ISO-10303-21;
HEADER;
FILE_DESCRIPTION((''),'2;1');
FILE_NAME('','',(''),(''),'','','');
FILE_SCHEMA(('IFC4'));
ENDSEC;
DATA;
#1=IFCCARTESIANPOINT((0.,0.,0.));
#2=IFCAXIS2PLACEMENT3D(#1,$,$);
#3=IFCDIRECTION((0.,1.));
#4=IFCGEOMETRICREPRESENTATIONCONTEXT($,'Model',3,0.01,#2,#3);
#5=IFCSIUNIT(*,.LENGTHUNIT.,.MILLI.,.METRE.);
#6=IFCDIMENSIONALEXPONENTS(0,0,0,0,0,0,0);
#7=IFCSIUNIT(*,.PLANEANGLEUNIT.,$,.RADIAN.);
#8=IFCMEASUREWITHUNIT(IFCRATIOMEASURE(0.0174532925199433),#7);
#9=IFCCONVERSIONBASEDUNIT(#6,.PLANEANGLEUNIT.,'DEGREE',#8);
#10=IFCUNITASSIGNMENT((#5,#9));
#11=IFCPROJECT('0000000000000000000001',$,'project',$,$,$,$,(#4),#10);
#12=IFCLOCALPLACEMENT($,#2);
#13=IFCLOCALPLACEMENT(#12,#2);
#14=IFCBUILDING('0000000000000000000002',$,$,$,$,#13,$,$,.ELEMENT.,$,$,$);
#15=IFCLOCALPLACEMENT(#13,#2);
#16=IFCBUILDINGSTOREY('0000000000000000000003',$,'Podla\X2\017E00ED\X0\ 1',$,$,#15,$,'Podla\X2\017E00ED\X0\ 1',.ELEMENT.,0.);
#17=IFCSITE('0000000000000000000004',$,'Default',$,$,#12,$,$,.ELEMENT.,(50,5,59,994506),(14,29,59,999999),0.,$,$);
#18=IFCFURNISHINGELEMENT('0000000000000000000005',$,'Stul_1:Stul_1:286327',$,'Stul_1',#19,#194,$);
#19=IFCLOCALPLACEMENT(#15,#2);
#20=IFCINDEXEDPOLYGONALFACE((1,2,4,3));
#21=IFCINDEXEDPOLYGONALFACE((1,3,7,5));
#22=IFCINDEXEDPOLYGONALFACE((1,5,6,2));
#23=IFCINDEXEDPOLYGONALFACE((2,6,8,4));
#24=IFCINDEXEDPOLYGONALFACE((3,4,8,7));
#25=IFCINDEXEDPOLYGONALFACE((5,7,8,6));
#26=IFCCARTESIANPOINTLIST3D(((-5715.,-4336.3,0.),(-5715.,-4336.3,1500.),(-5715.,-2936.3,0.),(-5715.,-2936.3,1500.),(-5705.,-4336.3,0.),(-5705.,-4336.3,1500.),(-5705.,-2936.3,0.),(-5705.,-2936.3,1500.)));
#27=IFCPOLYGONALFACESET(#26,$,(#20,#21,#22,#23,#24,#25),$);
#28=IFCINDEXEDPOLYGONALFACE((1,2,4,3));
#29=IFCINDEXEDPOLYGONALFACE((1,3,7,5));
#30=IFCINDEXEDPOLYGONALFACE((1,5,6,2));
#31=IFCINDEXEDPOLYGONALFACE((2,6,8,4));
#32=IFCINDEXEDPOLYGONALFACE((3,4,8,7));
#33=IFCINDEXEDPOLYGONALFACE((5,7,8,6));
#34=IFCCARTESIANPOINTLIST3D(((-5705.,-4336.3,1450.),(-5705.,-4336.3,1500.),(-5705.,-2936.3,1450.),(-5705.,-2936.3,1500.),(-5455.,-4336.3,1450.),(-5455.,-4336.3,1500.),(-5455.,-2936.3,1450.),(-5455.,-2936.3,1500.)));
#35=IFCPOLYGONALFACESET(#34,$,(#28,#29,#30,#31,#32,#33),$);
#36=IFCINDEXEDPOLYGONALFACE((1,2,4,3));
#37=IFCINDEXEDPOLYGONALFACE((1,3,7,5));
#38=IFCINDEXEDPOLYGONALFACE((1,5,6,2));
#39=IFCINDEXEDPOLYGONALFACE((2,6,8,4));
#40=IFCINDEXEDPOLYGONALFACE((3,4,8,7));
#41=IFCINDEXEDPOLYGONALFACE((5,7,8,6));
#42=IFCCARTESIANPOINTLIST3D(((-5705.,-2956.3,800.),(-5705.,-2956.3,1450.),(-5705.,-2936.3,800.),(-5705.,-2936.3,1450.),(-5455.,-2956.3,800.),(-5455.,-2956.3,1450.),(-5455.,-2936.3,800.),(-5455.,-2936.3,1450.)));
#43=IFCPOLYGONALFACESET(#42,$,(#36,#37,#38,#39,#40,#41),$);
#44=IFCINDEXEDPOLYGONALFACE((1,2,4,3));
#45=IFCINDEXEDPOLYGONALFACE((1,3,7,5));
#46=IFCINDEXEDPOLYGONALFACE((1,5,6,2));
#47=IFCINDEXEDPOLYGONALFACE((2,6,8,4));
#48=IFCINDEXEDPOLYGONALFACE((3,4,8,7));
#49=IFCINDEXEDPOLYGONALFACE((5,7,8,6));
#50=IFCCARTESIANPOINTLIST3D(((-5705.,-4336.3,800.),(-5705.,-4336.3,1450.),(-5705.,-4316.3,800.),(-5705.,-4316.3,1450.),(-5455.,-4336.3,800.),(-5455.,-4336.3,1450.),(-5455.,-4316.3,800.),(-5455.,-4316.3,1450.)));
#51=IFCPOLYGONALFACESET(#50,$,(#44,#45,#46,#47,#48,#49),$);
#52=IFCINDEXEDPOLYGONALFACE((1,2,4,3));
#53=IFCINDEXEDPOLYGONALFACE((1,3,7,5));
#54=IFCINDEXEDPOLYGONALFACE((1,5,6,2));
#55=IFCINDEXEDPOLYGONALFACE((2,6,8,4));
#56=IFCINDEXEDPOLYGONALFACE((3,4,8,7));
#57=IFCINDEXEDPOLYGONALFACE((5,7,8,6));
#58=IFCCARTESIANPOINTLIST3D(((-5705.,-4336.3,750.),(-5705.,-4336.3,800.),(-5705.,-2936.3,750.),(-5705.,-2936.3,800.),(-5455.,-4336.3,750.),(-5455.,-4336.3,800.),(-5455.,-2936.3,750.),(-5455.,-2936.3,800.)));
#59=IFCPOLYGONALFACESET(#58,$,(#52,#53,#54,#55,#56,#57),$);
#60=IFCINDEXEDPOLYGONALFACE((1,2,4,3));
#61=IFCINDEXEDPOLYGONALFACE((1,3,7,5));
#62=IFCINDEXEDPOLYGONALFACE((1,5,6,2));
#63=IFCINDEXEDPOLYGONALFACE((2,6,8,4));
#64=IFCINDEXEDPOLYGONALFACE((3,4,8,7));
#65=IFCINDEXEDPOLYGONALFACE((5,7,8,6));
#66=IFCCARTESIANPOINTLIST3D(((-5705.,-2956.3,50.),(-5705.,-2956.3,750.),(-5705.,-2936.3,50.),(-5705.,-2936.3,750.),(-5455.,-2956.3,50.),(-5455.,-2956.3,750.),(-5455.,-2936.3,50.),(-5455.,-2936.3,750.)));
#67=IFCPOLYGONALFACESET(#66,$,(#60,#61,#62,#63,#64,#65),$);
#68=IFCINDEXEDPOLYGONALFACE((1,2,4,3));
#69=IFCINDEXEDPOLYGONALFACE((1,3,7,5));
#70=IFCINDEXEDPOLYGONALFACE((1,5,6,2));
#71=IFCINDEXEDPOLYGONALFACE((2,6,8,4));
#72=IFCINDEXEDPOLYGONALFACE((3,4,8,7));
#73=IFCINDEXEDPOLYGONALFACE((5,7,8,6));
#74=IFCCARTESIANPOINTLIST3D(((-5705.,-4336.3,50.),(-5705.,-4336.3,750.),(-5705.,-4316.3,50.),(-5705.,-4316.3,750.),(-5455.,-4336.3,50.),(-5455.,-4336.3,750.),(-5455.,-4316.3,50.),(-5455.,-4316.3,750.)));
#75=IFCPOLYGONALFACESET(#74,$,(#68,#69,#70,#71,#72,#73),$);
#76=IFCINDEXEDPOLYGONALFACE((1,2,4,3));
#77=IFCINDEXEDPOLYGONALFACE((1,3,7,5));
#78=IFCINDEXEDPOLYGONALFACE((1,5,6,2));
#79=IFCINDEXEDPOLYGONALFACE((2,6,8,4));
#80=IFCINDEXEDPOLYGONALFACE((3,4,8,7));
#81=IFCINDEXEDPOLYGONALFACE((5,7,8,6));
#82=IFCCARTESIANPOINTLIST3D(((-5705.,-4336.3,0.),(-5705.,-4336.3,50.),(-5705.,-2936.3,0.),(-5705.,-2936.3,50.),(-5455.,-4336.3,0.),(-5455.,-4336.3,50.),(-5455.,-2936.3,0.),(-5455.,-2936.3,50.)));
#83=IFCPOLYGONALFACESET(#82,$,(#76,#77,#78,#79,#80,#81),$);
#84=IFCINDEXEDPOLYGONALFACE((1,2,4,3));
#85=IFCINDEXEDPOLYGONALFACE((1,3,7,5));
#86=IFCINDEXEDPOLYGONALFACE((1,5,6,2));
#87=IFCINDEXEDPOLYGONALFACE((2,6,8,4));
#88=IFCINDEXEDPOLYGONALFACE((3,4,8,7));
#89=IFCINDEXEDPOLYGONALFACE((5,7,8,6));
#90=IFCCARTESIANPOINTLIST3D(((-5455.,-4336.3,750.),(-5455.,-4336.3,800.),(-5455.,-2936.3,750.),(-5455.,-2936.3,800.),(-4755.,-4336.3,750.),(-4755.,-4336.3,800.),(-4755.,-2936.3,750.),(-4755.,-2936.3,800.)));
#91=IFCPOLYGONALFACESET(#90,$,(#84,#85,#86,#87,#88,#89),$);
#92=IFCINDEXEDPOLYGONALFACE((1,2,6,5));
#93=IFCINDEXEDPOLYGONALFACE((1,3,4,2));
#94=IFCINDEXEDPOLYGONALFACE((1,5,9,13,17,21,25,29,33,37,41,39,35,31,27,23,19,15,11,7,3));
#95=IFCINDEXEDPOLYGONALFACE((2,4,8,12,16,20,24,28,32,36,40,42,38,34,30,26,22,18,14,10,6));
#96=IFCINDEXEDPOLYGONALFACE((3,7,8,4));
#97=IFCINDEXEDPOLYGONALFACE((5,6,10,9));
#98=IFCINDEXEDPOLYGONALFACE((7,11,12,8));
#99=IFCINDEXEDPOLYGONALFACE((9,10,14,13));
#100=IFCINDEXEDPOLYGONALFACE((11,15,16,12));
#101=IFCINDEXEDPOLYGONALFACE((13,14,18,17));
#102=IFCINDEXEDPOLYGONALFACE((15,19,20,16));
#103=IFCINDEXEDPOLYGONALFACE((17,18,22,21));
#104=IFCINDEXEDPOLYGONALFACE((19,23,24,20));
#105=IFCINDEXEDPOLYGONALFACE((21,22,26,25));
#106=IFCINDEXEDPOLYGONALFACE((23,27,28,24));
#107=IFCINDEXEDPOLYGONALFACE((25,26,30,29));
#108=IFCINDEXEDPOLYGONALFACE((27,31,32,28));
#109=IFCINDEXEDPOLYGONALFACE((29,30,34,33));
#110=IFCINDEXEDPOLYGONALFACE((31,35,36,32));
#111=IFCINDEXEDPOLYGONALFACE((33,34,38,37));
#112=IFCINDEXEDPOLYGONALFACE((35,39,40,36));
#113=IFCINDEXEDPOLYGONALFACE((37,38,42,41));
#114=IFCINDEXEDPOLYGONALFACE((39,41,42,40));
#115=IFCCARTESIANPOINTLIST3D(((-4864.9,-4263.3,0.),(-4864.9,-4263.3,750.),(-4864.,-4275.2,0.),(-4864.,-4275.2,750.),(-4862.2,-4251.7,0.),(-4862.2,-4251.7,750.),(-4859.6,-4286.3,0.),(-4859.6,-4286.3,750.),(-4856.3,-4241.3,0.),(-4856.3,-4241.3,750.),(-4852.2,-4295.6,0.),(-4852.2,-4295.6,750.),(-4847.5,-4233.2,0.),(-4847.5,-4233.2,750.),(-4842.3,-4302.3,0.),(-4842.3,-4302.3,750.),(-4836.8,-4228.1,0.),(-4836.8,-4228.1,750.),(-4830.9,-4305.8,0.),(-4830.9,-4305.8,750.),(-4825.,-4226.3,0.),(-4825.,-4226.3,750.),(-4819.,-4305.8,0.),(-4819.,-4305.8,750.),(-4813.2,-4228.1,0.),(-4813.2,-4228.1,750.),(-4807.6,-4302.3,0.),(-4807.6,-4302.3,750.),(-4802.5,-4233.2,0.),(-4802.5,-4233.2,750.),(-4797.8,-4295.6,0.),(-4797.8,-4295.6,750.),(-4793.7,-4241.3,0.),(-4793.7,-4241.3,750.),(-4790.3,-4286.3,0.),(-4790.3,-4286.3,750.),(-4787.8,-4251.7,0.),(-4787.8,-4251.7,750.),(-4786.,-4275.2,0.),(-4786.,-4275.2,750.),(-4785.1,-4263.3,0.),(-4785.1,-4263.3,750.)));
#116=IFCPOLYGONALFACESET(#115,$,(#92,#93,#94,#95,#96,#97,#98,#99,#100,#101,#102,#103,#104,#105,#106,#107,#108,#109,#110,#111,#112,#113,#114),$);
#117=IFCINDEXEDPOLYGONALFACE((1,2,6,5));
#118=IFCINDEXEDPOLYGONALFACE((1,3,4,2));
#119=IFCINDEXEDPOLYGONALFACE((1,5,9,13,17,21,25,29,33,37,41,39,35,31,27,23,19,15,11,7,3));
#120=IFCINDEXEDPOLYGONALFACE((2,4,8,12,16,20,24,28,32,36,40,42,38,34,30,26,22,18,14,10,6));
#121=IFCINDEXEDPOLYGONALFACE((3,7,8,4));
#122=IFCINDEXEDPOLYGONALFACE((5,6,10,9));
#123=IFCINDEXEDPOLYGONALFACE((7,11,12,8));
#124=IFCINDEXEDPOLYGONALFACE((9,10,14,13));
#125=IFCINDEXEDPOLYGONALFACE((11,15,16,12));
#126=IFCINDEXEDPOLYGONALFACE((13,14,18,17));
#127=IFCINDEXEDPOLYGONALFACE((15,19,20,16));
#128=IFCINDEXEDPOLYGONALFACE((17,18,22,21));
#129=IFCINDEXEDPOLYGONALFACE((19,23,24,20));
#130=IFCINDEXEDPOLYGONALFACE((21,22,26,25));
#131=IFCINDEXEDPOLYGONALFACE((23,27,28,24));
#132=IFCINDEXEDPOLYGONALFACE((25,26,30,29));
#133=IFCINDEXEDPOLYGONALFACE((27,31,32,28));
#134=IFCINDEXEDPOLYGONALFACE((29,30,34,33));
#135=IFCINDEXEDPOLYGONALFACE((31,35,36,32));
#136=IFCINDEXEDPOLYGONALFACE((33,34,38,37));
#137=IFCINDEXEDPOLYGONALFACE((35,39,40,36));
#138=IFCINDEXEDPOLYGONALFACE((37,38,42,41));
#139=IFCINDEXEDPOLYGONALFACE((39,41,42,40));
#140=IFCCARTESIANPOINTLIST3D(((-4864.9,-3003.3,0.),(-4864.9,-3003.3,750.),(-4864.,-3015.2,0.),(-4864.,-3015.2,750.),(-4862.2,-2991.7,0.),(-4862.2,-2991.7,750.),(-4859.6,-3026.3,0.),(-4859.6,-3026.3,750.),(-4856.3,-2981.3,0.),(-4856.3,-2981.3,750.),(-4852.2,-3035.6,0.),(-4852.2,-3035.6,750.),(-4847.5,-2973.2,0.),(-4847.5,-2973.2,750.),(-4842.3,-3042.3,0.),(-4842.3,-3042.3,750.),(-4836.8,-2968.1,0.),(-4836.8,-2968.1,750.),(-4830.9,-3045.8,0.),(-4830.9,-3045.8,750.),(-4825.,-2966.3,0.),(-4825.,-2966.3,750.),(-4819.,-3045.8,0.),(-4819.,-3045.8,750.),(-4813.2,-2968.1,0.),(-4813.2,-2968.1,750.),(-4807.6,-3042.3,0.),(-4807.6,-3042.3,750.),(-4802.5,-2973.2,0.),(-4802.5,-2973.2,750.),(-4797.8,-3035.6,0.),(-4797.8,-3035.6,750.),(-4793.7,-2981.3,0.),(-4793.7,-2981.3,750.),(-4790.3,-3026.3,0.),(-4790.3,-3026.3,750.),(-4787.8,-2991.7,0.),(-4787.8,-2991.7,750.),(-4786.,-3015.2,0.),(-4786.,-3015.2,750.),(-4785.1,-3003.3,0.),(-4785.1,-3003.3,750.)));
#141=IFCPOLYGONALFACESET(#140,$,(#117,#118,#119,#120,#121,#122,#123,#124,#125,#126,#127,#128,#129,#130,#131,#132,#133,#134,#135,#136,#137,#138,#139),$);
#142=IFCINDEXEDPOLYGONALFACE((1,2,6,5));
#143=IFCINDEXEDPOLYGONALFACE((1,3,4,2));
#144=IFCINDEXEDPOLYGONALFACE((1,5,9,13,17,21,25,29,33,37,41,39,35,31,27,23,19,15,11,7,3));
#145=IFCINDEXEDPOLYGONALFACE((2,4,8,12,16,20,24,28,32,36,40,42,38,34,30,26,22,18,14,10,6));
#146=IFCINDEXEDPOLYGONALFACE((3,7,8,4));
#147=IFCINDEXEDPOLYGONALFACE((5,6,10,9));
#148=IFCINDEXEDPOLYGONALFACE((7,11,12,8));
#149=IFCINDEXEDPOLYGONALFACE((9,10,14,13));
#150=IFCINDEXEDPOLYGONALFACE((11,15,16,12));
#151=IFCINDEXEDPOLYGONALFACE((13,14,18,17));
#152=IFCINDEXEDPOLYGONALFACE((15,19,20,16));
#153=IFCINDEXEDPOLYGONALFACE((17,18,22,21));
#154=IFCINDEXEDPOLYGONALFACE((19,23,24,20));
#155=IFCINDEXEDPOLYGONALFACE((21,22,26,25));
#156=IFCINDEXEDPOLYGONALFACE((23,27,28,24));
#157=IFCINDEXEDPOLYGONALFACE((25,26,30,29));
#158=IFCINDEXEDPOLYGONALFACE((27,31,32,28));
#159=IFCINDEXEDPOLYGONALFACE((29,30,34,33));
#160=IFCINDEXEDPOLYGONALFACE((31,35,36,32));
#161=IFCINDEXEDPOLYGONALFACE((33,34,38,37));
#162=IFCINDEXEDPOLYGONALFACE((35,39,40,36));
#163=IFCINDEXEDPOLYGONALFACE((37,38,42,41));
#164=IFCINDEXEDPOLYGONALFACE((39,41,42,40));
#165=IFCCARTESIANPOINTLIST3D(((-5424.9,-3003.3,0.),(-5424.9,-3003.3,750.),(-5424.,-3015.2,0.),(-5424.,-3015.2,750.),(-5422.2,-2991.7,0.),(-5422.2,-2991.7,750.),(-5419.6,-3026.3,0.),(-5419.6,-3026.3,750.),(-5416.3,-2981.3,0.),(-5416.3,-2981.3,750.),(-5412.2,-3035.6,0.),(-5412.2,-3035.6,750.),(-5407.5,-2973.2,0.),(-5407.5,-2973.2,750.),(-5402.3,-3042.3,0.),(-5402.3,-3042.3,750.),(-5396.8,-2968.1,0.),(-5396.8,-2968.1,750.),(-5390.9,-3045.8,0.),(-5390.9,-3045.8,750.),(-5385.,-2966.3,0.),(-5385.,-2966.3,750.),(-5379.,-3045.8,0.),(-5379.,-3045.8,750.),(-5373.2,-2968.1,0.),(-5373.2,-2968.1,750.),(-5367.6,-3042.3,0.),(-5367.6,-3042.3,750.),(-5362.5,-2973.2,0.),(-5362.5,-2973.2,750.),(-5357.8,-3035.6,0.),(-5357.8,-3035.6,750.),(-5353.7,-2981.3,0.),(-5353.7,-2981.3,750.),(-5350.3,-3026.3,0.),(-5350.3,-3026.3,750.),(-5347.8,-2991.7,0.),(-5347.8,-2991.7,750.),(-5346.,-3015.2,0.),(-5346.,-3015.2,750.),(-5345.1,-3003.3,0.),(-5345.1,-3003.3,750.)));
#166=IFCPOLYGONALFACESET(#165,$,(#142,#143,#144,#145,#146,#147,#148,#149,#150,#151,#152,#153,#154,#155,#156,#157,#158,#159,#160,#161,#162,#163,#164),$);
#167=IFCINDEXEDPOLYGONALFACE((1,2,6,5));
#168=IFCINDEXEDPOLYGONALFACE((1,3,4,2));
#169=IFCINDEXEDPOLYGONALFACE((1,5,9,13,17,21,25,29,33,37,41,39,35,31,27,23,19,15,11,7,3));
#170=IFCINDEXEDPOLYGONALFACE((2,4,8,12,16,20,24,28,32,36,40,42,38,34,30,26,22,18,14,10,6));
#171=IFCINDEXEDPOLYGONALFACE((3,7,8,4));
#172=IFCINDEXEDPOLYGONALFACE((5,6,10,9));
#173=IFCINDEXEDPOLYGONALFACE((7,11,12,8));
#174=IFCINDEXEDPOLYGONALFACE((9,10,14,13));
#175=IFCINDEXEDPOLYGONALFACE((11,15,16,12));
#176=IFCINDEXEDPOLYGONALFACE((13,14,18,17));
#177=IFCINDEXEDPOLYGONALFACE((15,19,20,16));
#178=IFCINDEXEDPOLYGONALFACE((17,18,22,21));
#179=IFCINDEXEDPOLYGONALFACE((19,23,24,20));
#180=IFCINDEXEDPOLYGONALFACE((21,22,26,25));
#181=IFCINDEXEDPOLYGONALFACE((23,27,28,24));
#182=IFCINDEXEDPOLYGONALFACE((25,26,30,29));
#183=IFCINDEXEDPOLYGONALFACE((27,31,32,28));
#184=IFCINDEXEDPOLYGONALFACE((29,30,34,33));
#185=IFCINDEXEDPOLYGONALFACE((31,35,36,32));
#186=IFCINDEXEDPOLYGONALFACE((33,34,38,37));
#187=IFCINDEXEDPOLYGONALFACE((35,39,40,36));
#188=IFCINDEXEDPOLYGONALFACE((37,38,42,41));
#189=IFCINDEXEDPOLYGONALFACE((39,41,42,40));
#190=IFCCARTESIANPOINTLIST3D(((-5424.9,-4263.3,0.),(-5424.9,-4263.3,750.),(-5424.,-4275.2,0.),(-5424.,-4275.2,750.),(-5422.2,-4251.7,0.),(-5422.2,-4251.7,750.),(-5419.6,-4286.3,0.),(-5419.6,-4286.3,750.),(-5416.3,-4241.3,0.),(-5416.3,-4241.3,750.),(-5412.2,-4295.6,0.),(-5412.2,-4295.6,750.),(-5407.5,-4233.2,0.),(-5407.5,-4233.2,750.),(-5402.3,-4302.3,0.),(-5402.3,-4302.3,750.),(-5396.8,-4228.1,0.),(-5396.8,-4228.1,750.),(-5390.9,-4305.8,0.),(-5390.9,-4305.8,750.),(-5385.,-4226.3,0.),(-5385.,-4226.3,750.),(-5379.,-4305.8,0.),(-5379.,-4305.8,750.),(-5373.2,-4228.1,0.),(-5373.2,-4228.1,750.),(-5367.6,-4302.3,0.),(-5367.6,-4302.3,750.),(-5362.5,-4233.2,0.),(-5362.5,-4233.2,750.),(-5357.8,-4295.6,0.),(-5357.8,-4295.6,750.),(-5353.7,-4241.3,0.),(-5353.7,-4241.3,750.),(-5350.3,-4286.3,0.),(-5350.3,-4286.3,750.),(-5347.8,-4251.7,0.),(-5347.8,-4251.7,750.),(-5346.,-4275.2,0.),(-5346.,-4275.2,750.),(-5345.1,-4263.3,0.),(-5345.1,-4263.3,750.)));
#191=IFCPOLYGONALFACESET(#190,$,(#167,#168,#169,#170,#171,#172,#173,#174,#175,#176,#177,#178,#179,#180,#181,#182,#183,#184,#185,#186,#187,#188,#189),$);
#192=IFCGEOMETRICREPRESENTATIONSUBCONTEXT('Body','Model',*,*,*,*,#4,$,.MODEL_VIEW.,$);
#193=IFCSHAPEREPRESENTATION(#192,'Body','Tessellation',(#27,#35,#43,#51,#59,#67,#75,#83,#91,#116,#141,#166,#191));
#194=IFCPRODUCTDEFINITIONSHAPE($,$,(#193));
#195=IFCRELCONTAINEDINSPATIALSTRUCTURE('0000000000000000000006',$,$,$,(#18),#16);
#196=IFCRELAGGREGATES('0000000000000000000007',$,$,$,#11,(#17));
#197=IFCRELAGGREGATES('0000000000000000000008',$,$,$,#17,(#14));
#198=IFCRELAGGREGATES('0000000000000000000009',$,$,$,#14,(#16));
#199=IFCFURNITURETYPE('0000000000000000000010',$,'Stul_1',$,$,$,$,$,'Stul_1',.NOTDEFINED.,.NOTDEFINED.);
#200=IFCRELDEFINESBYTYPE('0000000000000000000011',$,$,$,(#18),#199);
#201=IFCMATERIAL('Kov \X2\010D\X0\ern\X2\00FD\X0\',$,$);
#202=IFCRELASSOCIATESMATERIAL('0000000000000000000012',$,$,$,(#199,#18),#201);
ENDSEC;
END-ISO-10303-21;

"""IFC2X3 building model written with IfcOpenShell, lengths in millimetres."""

from ifc_helpers import new_model, entity, si_unit, converted_unit, direction, frame, frame_2d, origin, origin_2d_with_axis, place, context, subcontext, project, spatial, rectangle, circle, extrude, source, transform, mapped, material, type_object, type_shapes, element, save


model = new_model("IFC2X3")

# Units and contexts
model_context = context("Model", 3, precision=0.01, world=origin(), true_north=direction((0.0, 1.0)))
body_context = subcontext(model_context, "Body", "Model", "MODEL_VIEW")
ifc_project = project(units=[si_unit("LENGTHUNIT", "METRE", prefix="MILLI"), converted_unit("PLANEANGLEUNIT", "DEGREE", entity("IfcRatioMeasure", 0.0174532925199433), si_unit("PLANEANGLEUNIT", "RADIAN"), dimensions=[0, 0, 0, 0, 0, 0, 0])], contexts=[model_context])

# Site, building, storey
site_placement = place(None, origin())
site = spatial("IfcSite", under=ifc_project, at=site_placement, Name="Default", CompositionType="ELEMENT", RefLatitude=(50, 5, 59, 994506), RefLongitude=(14, 29, 59, 999999), RefElevation=0.0)
building_placement = place(site_placement, origin())
building = spatial("IfcBuilding", under=site, at=building_placement, CompositionType="ELEMENT")
storey_placement = place(building_placement, origin())
storey = spatial("IfcBuildingStorey", under=building, at=storey_placement, Name="Podlaží 1", LongName="Podlaží 1", CompositionType="ELEMENT", Elevation=0.0)

# Furnishing element
ifc_material_1 = material(Name="Kov černý")
furniture_type = type_object("IfcFurnitureType", Name="Stul_1", ElementType="Stul_1", material=ifc_material_1)
shared_shape_1 = source(origin(), body_context, "Body", "SweptSolid", [
    extrude(rectangle(XDim=1400.0, YDim=10.0, at=origin_2d_with_axis()), frame((0.0, 605.0, 0.0), z_axis=(0.0, 0.0, 1.0), x_axis=(-1.0, 0.0, 0.0)), (0.0, 0.0, 1.0), 1500.0),
    extrude(rectangle(XDim=1400.0, YDim=250.0, at=frame_2d((0.0, 0.0), x_axis=(1.0, 0.0))), frame((0.0, 475.0, 1450.0), z_axis=(0.0, 0.0, 1.0), x_axis=(-1.0, 0.0, 0.0)), (0.0, 0.0, 1.0), 50.0),
    extrude(rectangle(XDim=20.0, YDim=250.0, at=origin_2d_with_axis()), frame((690.0, 475.0, 800.0), z_axis=(0.0, 0.0, 1.0), x_axis=(-1.0, 0.0, 0.0)), (0.0, 0.0, 1.0), 650.0),
    extrude(rectangle(XDim=20.0, YDim=250.0, at=frame_2d((0.0, 0.0), x_axis=(1.0, 0.0))), frame((-690.0, 475.0, 800.0), z_axis=(0.0, 0.0, 1.0), x_axis=(-1.0, 0.0, 0.0)), (0.0, 0.0, 1.0), 650.0),
    extrude(rectangle(XDim=1400.0, YDim=250.0, at=origin_2d_with_axis()), frame((0.0, 475.0, 750.0), z_axis=(0.0, 0.0, 1.0), x_axis=(-1.0, 0.0, 0.0)), (0.0, 0.0, 1.0), 50.0),
    extrude(rectangle(XDim=20.0, YDim=250.0, at=origin_2d_with_axis()), frame((690.0, 475.0, 50.0), z_axis=(0.0, 0.0, 1.0), x_axis=(-1.0, 0.0, 0.0)), (0.0, 0.0, 1.0), 700.0),
    extrude(rectangle(XDim=20.0, YDim=250.0, at=frame_2d((0.0, 0.0), x_axis=(1.0, 0.0))), frame((-690.0, 475.0, 50.0), z_axis=(0.0, 0.0, 1.0), x_axis=(-1.0, 0.0, 0.0)), (0.0, 0.0, 1.0), 700.0),
    extrude(rectangle(XDim=1400.0, YDim=250.0, at=origin_2d_with_axis()), frame((0.0, 475.0, 0.0), z_axis=(0.0, 0.0, 1.0), x_axis=(-1.0, 0.0, 0.0)), (0.0, 0.0, 1.0), 50.0),
    extrude(rectangle(XDim=1400.0, YDim=700.0, at=origin_2d_with_axis()), frame((0.0, 0.0, 750.0), z_axis=(0.0, 0.0, 1.0), x_axis=(-1.0, 0.0, 0.0)), (0.0, 0.0, 1.0), 50.0),
    extrude(circle(Radius=40.0, at=frame_2d((0.0, 0.0), x_axis=(1.0, 0.0))), frame((-630.0, -280.0, 0.0)), (0.0, 0.0, 1.0), 750.0),
    extrude(circle(Radius=40.0, at=frame_2d((0.0, 0.0), x_axis=(1.0, 0.0))), frame((630.0, -280.0, 0.0)), (0.0, 0.0, 1.0), 750.0),
    extrude(circle(Radius=40.0, at=frame_2d((0.0, 0.0), x_axis=(1.0, 0.0))), frame((630.0, 280.0, 0.0)), (0.0, 0.0, 1.0), 750.0),
    extrude(circle(Radius=40.0, at=frame_2d((0.0, 0.0), x_axis=(1.0, 0.0))), frame((-630.0, 280.0, 0.0)), (0.0, 0.0, 1.0), 750.0),
])
type_shapes(furniture_type, [shared_shape_1])
for number, where, z_axis, x_axis, name in (
    (1, (-5105.0, -3636.3, 0.0), (0.0, 0.0, 1.0), (0.0, 1.0, 0.0), "Stul_1:Stul_1:286327"),
):
    element("IfcFurnishingElement", number, at=place(storey_placement, frame(where, z_axis=z_axis, x_axis=x_axis)), inside=storey, type_object=furniture_type, material=ifc_material_1, Name=name, ObjectType="Stul_1", context=body_context, shape_type="MappedRepresentation", body=[
        mapped(shared_shape_1, transform((0.0, 0.0, 0.0), scale=1.0)),
    ])

save(model, "model.ifc")
